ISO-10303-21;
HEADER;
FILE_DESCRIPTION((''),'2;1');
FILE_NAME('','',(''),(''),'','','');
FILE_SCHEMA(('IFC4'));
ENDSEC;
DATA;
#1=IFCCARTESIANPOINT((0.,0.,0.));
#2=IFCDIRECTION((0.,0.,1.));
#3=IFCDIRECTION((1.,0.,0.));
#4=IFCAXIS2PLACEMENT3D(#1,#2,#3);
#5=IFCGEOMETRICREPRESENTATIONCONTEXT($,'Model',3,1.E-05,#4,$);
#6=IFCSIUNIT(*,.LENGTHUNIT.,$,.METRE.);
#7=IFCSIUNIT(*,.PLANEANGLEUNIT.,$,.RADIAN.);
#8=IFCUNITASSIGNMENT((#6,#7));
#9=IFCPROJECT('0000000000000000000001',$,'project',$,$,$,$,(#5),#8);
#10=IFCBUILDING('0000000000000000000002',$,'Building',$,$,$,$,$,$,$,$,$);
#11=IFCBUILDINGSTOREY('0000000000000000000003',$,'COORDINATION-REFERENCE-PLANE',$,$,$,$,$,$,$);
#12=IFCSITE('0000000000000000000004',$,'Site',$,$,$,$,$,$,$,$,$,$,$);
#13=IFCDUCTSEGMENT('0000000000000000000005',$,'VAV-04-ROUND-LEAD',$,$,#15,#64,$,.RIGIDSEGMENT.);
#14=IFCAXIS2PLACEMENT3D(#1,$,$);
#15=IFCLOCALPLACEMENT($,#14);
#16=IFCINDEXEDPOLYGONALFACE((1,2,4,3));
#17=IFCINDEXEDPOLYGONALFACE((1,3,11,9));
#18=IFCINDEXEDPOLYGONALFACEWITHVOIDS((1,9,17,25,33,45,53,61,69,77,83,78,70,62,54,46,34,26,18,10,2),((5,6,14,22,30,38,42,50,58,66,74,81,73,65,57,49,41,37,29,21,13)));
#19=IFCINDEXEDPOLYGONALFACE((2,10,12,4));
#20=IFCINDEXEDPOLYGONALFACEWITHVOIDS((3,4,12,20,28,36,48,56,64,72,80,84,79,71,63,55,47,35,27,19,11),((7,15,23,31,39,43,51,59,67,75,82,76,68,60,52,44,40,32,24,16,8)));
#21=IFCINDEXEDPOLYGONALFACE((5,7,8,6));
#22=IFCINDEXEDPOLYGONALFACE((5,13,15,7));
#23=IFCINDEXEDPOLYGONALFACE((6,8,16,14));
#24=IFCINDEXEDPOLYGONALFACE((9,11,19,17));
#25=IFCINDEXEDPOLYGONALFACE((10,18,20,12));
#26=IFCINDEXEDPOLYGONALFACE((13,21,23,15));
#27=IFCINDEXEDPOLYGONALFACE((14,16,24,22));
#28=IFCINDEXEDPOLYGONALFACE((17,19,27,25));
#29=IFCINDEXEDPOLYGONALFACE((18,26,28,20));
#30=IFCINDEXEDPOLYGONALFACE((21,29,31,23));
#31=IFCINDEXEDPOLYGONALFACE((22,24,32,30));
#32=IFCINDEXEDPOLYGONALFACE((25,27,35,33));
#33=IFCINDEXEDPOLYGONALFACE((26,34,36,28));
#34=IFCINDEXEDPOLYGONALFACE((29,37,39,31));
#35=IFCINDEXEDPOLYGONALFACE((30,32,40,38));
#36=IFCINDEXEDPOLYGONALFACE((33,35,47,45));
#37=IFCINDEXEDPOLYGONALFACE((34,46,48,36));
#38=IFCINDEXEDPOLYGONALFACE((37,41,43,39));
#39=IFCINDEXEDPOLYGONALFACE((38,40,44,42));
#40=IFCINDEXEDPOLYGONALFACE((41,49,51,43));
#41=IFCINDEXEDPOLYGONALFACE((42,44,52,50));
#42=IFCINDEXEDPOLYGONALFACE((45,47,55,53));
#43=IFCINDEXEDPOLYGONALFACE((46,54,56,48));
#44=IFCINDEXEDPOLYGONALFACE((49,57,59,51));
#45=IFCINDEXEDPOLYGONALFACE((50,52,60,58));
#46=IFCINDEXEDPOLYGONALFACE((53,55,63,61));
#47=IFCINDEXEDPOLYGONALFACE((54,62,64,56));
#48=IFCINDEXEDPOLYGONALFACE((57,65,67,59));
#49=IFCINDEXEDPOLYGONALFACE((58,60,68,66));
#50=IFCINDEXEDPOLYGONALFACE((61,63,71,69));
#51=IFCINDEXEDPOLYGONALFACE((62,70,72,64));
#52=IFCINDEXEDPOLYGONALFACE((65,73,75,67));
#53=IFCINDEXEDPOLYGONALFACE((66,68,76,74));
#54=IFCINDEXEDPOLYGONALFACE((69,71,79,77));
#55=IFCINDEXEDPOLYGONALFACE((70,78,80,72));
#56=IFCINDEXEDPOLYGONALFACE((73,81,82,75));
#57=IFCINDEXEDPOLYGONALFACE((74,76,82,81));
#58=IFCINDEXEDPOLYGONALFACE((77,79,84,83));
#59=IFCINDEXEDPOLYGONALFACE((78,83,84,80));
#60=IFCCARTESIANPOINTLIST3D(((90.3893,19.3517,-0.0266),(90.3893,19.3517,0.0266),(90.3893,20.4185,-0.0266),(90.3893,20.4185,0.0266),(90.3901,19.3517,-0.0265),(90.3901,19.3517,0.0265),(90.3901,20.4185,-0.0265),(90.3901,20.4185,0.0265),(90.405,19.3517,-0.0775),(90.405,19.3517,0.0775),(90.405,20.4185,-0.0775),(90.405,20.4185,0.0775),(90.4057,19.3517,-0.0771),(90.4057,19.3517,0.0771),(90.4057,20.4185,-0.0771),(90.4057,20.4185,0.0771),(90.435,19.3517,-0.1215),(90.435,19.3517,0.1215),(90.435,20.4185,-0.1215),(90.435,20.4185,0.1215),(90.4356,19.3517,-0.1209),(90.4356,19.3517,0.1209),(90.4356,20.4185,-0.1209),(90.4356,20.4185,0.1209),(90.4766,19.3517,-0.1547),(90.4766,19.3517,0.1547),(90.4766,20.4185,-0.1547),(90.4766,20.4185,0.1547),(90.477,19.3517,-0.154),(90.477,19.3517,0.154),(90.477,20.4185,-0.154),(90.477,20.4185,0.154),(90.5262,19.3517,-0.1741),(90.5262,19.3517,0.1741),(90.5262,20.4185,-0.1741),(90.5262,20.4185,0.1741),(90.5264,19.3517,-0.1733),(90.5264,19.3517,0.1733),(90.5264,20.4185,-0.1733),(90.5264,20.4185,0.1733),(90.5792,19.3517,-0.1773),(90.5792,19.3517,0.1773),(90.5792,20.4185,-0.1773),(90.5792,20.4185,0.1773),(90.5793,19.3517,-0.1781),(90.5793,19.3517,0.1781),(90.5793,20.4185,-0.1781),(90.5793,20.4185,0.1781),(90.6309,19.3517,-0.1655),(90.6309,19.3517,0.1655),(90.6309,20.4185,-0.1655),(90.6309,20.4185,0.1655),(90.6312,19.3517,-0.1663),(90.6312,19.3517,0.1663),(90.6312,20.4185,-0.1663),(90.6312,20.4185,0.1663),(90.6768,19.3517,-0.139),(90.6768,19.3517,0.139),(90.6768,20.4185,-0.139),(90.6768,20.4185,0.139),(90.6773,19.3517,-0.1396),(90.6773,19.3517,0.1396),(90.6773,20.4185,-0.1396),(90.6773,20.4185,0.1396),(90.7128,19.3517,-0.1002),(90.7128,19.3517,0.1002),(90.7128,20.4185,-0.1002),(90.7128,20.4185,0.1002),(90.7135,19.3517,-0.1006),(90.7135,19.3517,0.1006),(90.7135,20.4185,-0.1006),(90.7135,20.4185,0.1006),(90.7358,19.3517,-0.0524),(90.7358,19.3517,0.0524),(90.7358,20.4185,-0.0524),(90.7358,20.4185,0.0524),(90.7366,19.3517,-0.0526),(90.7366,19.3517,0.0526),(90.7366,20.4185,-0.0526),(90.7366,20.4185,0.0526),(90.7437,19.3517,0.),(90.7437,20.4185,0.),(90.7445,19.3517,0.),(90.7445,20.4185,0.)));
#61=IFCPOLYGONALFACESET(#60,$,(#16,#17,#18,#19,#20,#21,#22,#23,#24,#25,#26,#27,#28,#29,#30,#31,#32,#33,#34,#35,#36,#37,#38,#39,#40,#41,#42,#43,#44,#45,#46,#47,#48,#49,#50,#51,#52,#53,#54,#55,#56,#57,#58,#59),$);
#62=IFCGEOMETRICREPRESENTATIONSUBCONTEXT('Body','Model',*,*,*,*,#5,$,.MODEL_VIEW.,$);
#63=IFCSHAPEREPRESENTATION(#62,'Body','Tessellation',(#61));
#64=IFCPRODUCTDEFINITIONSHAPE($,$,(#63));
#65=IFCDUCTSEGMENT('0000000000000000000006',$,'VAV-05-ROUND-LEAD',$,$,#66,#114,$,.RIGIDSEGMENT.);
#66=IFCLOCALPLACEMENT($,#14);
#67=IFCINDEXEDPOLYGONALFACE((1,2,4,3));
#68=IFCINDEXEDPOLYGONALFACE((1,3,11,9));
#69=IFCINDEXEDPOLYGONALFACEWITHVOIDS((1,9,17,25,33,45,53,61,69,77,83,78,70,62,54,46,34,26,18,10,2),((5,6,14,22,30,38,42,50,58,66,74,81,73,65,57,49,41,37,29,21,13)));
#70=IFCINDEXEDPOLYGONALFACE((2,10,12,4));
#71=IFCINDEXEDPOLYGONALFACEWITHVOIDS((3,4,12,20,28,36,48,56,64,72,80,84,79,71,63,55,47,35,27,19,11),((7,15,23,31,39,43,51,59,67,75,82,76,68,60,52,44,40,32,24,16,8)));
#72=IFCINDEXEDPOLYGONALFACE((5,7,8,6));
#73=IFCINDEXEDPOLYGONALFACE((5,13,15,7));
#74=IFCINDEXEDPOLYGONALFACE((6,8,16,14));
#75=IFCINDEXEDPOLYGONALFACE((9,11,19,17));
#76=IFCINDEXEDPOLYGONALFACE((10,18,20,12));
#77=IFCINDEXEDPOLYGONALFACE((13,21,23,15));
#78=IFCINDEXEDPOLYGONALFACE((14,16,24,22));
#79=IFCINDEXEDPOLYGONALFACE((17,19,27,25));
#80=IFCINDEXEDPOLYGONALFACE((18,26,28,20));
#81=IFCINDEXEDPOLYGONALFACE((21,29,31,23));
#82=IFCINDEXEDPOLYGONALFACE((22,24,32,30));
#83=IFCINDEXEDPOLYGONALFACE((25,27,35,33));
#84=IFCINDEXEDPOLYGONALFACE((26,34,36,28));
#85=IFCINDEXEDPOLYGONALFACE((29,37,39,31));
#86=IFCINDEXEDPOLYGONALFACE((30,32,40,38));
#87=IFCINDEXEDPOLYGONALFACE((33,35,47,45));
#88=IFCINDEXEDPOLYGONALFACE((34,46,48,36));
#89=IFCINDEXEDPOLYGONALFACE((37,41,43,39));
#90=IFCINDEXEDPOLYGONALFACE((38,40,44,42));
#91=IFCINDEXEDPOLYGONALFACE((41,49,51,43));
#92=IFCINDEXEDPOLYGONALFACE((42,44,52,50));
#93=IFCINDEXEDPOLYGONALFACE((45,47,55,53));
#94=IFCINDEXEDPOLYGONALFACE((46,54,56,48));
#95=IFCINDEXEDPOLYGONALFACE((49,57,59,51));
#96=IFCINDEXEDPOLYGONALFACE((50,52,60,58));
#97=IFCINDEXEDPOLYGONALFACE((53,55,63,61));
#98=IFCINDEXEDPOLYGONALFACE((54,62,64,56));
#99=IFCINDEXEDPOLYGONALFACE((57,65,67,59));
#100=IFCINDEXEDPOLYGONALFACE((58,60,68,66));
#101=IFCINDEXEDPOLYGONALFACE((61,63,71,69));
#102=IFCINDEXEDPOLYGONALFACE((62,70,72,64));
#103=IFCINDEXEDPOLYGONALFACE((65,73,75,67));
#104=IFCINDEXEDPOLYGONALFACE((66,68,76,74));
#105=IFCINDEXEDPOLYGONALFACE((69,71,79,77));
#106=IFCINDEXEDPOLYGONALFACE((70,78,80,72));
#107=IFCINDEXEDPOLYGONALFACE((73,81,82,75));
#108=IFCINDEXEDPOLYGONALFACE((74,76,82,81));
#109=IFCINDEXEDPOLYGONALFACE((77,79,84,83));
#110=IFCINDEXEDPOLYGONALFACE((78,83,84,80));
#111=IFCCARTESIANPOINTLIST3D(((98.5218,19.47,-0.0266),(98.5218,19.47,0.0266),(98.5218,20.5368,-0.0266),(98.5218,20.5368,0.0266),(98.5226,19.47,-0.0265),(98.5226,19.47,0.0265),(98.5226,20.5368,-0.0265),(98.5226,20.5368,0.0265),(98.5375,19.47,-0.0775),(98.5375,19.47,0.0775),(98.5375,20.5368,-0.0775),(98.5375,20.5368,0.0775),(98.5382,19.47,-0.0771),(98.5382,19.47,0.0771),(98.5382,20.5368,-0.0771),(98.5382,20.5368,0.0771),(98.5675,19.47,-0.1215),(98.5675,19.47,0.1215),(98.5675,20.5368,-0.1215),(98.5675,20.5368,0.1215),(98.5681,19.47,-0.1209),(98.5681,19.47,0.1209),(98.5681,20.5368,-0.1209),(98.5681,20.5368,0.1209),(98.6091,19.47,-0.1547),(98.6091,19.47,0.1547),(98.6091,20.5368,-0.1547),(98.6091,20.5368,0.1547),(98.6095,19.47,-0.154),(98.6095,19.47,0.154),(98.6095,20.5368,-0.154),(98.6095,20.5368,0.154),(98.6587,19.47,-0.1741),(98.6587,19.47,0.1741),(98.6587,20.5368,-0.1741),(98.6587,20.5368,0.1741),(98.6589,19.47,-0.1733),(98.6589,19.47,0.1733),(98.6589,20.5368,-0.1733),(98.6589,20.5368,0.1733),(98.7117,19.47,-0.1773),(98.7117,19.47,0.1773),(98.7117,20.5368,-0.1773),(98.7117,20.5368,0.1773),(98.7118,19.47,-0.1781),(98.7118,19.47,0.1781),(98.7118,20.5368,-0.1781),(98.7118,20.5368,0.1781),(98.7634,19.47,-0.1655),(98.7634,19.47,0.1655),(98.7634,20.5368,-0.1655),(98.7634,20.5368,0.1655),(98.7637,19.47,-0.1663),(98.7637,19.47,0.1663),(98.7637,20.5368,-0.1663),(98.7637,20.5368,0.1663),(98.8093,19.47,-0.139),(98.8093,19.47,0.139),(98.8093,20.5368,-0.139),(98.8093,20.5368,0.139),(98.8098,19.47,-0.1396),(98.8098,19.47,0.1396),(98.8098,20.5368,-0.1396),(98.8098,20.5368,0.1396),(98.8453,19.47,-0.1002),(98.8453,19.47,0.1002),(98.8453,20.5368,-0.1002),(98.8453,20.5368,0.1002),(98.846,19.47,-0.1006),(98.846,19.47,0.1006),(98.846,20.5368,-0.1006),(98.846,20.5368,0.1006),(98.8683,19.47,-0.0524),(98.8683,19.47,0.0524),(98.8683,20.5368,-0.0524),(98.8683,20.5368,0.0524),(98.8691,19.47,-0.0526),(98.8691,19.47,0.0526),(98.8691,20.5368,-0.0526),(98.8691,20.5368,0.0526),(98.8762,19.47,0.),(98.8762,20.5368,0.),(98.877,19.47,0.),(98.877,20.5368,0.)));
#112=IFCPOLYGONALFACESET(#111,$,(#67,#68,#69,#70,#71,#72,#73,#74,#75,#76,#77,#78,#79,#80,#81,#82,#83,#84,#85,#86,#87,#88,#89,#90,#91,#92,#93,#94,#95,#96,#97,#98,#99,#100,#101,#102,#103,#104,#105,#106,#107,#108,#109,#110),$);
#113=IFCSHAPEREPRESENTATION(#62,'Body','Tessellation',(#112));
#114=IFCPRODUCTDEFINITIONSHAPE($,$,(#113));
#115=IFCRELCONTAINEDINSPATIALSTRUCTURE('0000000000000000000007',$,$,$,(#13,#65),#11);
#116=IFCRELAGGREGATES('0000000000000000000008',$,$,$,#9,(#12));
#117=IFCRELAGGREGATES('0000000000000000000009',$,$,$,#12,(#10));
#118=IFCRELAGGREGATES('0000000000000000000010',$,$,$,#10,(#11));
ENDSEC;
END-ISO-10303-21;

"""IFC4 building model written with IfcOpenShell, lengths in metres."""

from ifc_helpers import new_model, si_unit, frame, origin, origin_with_axes, place, context, subcontext, project, spatial, hollow_circle, extrude, element, save


model = new_model("IFC4")

# Units and contexts
model_context_1 = context("Model", 3, precision=1e-05, world=origin_with_axes())
body_context_1 = subcontext(model_context_1, "Body", "Model", "MODEL_VIEW")
ifc_project = project(units=[si_unit("LENGTHUNIT", "METRE"), si_unit("PLANEANGLEUNIT", "RADIAN")], contexts=[model_context_1])

# Site, building, storey
site = spatial("IfcSite", under=ifc_project, Name="Site")
building = spatial("IfcBuilding", under=site, Name="Building")
storey = spatial("IfcBuildingStorey", under=building, Name="COORDINATION-REFERENCE-PLANE")

# Duct segments
for number, where, z_axis, x_axis, name in (
    (1, (90.5659, 20.4185, 0.0), (0.0, -1.0, 0.0), (1.0, 0.0, 0.0), "VAV-04-ROUND-LEAD"),
    (2, (98.6984, 20.5368, 0.0), (0.0, -1.0, 0.0), (1.0, 0.0, 0.0), "VAV-05-ROUND-LEAD"),
):
    element("IfcDuctSegment", number, at=place(None, frame(where, z_axis=z_axis, x_axis=x_axis)), inside=storey, Name=name, PredefinedType="RIGIDSEGMENT", context=body_context_1, shape_type="SweptSolid", body=[
        extrude(hollow_circle(Radius=0.1786, WallThickness=0.0008), origin(), (0.0, 0.0, 1.0), 1.0668),
    ])

save(model, "model.ifc")
